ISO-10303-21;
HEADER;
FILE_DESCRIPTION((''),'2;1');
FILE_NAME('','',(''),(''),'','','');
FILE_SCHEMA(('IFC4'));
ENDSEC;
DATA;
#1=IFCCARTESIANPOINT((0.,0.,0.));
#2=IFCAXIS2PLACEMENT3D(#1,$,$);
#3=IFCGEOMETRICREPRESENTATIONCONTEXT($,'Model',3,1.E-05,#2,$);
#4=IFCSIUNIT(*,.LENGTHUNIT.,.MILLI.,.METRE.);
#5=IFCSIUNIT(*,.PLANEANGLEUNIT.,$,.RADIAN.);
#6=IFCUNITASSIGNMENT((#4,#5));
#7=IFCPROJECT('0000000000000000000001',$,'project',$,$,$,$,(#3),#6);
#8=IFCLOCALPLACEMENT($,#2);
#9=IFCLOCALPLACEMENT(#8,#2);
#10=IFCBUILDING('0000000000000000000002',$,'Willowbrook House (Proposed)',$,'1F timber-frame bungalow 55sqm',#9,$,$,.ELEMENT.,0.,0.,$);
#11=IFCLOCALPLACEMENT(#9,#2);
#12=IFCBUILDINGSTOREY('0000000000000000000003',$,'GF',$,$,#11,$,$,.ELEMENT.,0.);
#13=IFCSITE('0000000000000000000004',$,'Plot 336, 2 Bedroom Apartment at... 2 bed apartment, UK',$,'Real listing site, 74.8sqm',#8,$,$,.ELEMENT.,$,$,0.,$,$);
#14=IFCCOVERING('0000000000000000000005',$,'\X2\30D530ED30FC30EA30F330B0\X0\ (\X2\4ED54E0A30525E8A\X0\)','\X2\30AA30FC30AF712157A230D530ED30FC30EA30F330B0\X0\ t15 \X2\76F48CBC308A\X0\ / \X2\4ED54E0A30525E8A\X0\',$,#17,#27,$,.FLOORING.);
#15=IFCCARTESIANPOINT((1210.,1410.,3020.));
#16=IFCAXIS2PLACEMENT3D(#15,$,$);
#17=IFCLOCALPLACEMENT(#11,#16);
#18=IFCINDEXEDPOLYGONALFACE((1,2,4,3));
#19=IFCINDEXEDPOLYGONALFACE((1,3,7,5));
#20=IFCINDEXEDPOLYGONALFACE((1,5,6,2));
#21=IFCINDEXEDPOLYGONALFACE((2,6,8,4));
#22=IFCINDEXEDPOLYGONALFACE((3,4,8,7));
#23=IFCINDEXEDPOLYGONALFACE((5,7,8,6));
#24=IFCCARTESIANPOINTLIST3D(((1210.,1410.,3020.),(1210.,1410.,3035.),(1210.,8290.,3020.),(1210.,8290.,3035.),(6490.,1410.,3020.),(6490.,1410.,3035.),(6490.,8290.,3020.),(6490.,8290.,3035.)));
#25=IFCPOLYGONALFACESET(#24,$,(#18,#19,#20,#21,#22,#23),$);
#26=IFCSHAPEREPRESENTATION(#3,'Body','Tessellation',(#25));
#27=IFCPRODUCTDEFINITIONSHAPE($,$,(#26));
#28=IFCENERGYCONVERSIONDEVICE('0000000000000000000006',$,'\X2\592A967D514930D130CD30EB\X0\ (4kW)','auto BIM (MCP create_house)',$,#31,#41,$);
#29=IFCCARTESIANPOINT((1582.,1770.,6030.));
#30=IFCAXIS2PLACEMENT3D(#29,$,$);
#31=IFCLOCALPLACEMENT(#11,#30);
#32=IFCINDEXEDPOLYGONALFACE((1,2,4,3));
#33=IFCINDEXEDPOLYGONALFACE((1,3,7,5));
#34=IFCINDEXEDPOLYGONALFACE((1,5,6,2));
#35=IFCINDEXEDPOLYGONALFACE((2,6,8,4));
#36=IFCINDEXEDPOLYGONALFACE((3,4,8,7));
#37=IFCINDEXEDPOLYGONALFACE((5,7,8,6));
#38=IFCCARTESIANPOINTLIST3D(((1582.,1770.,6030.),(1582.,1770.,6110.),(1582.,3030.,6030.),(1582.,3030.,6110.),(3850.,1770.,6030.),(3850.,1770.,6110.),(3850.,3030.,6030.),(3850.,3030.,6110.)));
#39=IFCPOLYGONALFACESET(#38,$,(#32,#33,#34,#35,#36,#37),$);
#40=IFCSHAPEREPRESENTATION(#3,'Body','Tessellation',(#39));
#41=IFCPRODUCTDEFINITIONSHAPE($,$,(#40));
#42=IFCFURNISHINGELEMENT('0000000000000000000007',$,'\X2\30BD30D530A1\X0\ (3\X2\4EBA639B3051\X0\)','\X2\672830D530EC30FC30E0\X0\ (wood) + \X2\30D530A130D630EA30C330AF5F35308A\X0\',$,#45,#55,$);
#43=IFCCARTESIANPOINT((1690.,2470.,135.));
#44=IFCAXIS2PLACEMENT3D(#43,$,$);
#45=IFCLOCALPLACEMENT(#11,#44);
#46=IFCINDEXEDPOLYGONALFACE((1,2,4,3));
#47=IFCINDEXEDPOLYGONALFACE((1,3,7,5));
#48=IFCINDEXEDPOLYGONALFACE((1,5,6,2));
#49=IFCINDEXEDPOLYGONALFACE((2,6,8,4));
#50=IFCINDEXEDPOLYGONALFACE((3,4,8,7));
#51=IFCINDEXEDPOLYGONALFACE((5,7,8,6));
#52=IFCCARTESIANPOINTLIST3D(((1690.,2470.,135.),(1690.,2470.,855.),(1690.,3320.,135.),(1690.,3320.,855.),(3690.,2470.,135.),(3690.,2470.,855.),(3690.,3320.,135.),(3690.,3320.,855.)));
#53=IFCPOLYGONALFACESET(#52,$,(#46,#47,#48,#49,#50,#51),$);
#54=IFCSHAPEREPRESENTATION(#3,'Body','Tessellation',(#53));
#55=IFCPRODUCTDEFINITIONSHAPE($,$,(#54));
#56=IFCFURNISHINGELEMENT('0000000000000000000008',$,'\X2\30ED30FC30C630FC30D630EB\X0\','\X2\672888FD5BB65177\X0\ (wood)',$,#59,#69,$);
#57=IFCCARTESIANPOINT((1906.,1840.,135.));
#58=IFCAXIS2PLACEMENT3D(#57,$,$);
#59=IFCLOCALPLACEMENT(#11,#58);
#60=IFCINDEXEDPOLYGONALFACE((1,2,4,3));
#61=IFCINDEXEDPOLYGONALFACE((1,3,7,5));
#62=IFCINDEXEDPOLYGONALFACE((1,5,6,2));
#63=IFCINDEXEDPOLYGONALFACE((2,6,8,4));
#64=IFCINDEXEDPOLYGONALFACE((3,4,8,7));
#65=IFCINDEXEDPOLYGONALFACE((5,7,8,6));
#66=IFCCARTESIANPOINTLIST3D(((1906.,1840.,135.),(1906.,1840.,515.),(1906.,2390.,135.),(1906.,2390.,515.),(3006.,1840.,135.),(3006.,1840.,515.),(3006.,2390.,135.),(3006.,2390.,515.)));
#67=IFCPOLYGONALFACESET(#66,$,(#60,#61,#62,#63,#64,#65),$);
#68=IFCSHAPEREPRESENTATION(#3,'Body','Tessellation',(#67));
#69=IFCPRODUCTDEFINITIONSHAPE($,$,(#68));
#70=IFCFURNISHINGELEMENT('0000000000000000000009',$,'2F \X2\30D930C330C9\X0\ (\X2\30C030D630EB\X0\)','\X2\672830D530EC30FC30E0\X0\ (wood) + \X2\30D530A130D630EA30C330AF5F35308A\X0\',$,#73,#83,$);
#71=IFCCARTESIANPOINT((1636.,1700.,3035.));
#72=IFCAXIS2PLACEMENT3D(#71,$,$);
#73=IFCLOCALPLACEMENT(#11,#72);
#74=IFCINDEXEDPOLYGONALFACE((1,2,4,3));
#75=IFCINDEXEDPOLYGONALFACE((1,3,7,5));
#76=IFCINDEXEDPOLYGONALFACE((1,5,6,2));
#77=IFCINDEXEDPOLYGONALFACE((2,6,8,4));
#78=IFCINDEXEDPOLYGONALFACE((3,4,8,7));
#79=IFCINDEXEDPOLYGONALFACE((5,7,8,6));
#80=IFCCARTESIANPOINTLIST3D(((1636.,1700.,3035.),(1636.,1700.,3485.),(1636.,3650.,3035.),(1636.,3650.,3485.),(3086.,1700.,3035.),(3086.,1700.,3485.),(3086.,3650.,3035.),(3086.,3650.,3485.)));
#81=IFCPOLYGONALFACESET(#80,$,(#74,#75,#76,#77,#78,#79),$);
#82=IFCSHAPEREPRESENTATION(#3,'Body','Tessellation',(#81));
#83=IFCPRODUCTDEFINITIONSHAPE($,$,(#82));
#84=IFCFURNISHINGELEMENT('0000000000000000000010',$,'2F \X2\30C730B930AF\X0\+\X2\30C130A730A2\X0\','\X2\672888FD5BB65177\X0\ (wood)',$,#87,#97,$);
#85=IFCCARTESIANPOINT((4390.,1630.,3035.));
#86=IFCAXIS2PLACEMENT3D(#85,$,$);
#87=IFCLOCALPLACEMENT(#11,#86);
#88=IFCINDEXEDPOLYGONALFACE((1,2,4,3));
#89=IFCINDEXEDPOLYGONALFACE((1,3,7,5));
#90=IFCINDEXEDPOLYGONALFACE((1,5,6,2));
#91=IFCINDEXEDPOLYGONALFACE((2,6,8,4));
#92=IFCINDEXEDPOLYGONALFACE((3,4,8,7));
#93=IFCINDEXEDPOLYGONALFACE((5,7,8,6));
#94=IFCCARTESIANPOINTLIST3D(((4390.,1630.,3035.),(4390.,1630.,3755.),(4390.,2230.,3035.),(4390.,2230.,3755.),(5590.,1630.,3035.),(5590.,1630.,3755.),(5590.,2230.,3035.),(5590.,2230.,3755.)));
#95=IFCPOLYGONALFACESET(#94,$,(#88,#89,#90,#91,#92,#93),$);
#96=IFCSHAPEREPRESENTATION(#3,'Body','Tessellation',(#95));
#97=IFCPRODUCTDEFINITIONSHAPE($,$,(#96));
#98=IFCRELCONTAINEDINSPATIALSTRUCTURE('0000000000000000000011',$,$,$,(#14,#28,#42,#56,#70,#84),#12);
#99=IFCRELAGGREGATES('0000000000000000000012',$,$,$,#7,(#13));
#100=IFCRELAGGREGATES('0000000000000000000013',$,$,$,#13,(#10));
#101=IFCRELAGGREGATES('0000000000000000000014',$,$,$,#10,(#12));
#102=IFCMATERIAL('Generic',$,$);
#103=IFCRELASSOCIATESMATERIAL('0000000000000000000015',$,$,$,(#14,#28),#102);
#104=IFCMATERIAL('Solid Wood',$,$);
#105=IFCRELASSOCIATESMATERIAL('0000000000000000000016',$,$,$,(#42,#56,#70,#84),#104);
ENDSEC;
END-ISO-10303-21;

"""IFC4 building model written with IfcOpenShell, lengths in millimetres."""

from ifc_helpers import new_model, si_unit, frame, frame_2d, origin, place, context, project, spatial, rectangle, extrude, material, element, save


model = new_model("IFC4")

# Units and contexts
model_context = context("Model", 3, precision=1e-05, world=origin())
ifc_project = project(units=[si_unit("LENGTHUNIT", "METRE", prefix="MILLI"), si_unit("PLANEANGLEUNIT", "RADIAN")], contexts=[model_context])

# Site, building, storey
site_placement = place(None, origin())
site = spatial("IfcSite", under=ifc_project, at=site_placement, Name="Plot 336, 2 Bedroom Apartment at... 2 bed apartment, UK", ObjectType="Real listing site, 74.8sqm", CompositionType="ELEMENT", RefElevation=0.0)
building_placement = place(site_placement, origin())
building = spatial("IfcBuilding", under=site, at=building_placement, Name="Willowbrook House (Proposed)", ObjectType="1F timber-frame bungalow 55sqm", CompositionType="ELEMENT", ElevationOfRefHeight=0.0, ElevationOfTerrain=0.0)
storey_placement = place(building_placement, origin())
storey = spatial("IfcBuildingStorey", under=building, at=storey_placement, Name="GF", CompositionType="ELEMENT", Elevation=0.0)

# Shared definitions
ifc_material_1 = material(Name="Solid Wood")

# Shared definitions
ifc_material_2 = material(Name="Generic")

# Covering
covering_placement = place(storey_placement, frame((1210.0, 1410.0, 3020.0)))
element("IfcCovering", 1, at=covering_placement, inside=storey, material=ifc_material_2, Name="フローリング (仕上げ床)", Description="オーク無垢フローリング t15 直貼り / 仕上げ床", PredefinedType="FLOORING", context=model_context, shape_type="SweptSolid", body=[
    extrude(rectangle(XDim=5280.0, YDim=6880.0, at=frame_2d((2640.0, 3440.0))), frame((1210.0, 1410.0, 3020.0)), (0.0, 0.0, 1.0), 15.0),
])

# Energy conversion device
energy_conversion_device_placement = place(storey_placement, frame((1582.0, 1770.0, 6030.0)))
element("IfcEnergyConversionDevice", 2, at=energy_conversion_device_placement, inside=storey, material=ifc_material_2, Name="太陽光パネル (4kW)", Description="auto BIM (MCP create_house)", context=model_context, shape_type="SweptSolid", body=[
    extrude(rectangle(XDim=2268.0, YDim=1260.0, at=frame_2d((1134.0, 630.0))), frame((1582.0, 1770.0, 6030.0)), (0.0, 0.0, 1.0), 80.0),
])

# Furnishing elements
furnishing_1_placement = place(storey_placement, frame((1690.0, 2470.0, 135.0)))
element("IfcFurnishingElement", 3, at=furnishing_1_placement, inside=storey, material=ifc_material_1, Name="ソファ (3人掛け)", Description="木フレーム (wood) + ファブリック張り", context=model_context, shape_type="SweptSolid", body=[
    extrude(rectangle(XDim=2000.0, YDim=850.0, at=frame_2d((1000.0, 425.0))), frame((1690.0, 2470.0, 135.0)), (0.0, 0.0, 1.0), 720.0),
])
furnishing_2_placement = place(storey_placement, frame((1906.0, 1840.0, 135.0)))
element("IfcFurnishingElement", 4, at=furnishing_2_placement, inside=storey, material=ifc_material_1, Name="ローテーブル", Description="木製家具 (wood)", context=model_context, shape_type="SweptSolid", body=[
    extrude(rectangle(XDim=1100.0, YDim=550.0, at=frame_2d((550.0, 275.0))), frame((1906.0, 1840.0, 135.0)), (0.0, 0.0, 1.0), 380.0),
])
furnishing_3_placement = place(storey_placement, frame((1636.0, 1700.0, 3035.0)))
element("IfcFurnishingElement", 5, at=furnishing_3_placement, inside=storey, material=ifc_material_1, Name="2F ベッド (ダブル)", Description="木フレーム (wood) + ファブリック張り", context=model_context, shape_type="SweptSolid", body=[
    extrude(rectangle(XDim=1450.0, YDim=1950.0, at=frame_2d((725.0, 975.0))), frame((1636.0, 1700.0, 3035.0)), (0.0, 0.0, 1.0), 450.0),
])
furnishing_4_placement = place(storey_placement, frame((4390.0, 1630.0, 3035.0)))
element("IfcFurnishingElement", 6, at=furnishing_4_placement, inside=storey, material=ifc_material_1, Name="2F デスク+チェア", Description="木製家具 (wood)", context=model_context, shape_type="SweptSolid", body=[
    extrude(rectangle(XDim=1200.0, YDim=600.0, at=frame_2d((600.0, 300.0))), frame((4390.0, 1630.0, 3035.0)), (0.0, 0.0, 1.0), 720.0),
])

save(model, "model.ifc")
